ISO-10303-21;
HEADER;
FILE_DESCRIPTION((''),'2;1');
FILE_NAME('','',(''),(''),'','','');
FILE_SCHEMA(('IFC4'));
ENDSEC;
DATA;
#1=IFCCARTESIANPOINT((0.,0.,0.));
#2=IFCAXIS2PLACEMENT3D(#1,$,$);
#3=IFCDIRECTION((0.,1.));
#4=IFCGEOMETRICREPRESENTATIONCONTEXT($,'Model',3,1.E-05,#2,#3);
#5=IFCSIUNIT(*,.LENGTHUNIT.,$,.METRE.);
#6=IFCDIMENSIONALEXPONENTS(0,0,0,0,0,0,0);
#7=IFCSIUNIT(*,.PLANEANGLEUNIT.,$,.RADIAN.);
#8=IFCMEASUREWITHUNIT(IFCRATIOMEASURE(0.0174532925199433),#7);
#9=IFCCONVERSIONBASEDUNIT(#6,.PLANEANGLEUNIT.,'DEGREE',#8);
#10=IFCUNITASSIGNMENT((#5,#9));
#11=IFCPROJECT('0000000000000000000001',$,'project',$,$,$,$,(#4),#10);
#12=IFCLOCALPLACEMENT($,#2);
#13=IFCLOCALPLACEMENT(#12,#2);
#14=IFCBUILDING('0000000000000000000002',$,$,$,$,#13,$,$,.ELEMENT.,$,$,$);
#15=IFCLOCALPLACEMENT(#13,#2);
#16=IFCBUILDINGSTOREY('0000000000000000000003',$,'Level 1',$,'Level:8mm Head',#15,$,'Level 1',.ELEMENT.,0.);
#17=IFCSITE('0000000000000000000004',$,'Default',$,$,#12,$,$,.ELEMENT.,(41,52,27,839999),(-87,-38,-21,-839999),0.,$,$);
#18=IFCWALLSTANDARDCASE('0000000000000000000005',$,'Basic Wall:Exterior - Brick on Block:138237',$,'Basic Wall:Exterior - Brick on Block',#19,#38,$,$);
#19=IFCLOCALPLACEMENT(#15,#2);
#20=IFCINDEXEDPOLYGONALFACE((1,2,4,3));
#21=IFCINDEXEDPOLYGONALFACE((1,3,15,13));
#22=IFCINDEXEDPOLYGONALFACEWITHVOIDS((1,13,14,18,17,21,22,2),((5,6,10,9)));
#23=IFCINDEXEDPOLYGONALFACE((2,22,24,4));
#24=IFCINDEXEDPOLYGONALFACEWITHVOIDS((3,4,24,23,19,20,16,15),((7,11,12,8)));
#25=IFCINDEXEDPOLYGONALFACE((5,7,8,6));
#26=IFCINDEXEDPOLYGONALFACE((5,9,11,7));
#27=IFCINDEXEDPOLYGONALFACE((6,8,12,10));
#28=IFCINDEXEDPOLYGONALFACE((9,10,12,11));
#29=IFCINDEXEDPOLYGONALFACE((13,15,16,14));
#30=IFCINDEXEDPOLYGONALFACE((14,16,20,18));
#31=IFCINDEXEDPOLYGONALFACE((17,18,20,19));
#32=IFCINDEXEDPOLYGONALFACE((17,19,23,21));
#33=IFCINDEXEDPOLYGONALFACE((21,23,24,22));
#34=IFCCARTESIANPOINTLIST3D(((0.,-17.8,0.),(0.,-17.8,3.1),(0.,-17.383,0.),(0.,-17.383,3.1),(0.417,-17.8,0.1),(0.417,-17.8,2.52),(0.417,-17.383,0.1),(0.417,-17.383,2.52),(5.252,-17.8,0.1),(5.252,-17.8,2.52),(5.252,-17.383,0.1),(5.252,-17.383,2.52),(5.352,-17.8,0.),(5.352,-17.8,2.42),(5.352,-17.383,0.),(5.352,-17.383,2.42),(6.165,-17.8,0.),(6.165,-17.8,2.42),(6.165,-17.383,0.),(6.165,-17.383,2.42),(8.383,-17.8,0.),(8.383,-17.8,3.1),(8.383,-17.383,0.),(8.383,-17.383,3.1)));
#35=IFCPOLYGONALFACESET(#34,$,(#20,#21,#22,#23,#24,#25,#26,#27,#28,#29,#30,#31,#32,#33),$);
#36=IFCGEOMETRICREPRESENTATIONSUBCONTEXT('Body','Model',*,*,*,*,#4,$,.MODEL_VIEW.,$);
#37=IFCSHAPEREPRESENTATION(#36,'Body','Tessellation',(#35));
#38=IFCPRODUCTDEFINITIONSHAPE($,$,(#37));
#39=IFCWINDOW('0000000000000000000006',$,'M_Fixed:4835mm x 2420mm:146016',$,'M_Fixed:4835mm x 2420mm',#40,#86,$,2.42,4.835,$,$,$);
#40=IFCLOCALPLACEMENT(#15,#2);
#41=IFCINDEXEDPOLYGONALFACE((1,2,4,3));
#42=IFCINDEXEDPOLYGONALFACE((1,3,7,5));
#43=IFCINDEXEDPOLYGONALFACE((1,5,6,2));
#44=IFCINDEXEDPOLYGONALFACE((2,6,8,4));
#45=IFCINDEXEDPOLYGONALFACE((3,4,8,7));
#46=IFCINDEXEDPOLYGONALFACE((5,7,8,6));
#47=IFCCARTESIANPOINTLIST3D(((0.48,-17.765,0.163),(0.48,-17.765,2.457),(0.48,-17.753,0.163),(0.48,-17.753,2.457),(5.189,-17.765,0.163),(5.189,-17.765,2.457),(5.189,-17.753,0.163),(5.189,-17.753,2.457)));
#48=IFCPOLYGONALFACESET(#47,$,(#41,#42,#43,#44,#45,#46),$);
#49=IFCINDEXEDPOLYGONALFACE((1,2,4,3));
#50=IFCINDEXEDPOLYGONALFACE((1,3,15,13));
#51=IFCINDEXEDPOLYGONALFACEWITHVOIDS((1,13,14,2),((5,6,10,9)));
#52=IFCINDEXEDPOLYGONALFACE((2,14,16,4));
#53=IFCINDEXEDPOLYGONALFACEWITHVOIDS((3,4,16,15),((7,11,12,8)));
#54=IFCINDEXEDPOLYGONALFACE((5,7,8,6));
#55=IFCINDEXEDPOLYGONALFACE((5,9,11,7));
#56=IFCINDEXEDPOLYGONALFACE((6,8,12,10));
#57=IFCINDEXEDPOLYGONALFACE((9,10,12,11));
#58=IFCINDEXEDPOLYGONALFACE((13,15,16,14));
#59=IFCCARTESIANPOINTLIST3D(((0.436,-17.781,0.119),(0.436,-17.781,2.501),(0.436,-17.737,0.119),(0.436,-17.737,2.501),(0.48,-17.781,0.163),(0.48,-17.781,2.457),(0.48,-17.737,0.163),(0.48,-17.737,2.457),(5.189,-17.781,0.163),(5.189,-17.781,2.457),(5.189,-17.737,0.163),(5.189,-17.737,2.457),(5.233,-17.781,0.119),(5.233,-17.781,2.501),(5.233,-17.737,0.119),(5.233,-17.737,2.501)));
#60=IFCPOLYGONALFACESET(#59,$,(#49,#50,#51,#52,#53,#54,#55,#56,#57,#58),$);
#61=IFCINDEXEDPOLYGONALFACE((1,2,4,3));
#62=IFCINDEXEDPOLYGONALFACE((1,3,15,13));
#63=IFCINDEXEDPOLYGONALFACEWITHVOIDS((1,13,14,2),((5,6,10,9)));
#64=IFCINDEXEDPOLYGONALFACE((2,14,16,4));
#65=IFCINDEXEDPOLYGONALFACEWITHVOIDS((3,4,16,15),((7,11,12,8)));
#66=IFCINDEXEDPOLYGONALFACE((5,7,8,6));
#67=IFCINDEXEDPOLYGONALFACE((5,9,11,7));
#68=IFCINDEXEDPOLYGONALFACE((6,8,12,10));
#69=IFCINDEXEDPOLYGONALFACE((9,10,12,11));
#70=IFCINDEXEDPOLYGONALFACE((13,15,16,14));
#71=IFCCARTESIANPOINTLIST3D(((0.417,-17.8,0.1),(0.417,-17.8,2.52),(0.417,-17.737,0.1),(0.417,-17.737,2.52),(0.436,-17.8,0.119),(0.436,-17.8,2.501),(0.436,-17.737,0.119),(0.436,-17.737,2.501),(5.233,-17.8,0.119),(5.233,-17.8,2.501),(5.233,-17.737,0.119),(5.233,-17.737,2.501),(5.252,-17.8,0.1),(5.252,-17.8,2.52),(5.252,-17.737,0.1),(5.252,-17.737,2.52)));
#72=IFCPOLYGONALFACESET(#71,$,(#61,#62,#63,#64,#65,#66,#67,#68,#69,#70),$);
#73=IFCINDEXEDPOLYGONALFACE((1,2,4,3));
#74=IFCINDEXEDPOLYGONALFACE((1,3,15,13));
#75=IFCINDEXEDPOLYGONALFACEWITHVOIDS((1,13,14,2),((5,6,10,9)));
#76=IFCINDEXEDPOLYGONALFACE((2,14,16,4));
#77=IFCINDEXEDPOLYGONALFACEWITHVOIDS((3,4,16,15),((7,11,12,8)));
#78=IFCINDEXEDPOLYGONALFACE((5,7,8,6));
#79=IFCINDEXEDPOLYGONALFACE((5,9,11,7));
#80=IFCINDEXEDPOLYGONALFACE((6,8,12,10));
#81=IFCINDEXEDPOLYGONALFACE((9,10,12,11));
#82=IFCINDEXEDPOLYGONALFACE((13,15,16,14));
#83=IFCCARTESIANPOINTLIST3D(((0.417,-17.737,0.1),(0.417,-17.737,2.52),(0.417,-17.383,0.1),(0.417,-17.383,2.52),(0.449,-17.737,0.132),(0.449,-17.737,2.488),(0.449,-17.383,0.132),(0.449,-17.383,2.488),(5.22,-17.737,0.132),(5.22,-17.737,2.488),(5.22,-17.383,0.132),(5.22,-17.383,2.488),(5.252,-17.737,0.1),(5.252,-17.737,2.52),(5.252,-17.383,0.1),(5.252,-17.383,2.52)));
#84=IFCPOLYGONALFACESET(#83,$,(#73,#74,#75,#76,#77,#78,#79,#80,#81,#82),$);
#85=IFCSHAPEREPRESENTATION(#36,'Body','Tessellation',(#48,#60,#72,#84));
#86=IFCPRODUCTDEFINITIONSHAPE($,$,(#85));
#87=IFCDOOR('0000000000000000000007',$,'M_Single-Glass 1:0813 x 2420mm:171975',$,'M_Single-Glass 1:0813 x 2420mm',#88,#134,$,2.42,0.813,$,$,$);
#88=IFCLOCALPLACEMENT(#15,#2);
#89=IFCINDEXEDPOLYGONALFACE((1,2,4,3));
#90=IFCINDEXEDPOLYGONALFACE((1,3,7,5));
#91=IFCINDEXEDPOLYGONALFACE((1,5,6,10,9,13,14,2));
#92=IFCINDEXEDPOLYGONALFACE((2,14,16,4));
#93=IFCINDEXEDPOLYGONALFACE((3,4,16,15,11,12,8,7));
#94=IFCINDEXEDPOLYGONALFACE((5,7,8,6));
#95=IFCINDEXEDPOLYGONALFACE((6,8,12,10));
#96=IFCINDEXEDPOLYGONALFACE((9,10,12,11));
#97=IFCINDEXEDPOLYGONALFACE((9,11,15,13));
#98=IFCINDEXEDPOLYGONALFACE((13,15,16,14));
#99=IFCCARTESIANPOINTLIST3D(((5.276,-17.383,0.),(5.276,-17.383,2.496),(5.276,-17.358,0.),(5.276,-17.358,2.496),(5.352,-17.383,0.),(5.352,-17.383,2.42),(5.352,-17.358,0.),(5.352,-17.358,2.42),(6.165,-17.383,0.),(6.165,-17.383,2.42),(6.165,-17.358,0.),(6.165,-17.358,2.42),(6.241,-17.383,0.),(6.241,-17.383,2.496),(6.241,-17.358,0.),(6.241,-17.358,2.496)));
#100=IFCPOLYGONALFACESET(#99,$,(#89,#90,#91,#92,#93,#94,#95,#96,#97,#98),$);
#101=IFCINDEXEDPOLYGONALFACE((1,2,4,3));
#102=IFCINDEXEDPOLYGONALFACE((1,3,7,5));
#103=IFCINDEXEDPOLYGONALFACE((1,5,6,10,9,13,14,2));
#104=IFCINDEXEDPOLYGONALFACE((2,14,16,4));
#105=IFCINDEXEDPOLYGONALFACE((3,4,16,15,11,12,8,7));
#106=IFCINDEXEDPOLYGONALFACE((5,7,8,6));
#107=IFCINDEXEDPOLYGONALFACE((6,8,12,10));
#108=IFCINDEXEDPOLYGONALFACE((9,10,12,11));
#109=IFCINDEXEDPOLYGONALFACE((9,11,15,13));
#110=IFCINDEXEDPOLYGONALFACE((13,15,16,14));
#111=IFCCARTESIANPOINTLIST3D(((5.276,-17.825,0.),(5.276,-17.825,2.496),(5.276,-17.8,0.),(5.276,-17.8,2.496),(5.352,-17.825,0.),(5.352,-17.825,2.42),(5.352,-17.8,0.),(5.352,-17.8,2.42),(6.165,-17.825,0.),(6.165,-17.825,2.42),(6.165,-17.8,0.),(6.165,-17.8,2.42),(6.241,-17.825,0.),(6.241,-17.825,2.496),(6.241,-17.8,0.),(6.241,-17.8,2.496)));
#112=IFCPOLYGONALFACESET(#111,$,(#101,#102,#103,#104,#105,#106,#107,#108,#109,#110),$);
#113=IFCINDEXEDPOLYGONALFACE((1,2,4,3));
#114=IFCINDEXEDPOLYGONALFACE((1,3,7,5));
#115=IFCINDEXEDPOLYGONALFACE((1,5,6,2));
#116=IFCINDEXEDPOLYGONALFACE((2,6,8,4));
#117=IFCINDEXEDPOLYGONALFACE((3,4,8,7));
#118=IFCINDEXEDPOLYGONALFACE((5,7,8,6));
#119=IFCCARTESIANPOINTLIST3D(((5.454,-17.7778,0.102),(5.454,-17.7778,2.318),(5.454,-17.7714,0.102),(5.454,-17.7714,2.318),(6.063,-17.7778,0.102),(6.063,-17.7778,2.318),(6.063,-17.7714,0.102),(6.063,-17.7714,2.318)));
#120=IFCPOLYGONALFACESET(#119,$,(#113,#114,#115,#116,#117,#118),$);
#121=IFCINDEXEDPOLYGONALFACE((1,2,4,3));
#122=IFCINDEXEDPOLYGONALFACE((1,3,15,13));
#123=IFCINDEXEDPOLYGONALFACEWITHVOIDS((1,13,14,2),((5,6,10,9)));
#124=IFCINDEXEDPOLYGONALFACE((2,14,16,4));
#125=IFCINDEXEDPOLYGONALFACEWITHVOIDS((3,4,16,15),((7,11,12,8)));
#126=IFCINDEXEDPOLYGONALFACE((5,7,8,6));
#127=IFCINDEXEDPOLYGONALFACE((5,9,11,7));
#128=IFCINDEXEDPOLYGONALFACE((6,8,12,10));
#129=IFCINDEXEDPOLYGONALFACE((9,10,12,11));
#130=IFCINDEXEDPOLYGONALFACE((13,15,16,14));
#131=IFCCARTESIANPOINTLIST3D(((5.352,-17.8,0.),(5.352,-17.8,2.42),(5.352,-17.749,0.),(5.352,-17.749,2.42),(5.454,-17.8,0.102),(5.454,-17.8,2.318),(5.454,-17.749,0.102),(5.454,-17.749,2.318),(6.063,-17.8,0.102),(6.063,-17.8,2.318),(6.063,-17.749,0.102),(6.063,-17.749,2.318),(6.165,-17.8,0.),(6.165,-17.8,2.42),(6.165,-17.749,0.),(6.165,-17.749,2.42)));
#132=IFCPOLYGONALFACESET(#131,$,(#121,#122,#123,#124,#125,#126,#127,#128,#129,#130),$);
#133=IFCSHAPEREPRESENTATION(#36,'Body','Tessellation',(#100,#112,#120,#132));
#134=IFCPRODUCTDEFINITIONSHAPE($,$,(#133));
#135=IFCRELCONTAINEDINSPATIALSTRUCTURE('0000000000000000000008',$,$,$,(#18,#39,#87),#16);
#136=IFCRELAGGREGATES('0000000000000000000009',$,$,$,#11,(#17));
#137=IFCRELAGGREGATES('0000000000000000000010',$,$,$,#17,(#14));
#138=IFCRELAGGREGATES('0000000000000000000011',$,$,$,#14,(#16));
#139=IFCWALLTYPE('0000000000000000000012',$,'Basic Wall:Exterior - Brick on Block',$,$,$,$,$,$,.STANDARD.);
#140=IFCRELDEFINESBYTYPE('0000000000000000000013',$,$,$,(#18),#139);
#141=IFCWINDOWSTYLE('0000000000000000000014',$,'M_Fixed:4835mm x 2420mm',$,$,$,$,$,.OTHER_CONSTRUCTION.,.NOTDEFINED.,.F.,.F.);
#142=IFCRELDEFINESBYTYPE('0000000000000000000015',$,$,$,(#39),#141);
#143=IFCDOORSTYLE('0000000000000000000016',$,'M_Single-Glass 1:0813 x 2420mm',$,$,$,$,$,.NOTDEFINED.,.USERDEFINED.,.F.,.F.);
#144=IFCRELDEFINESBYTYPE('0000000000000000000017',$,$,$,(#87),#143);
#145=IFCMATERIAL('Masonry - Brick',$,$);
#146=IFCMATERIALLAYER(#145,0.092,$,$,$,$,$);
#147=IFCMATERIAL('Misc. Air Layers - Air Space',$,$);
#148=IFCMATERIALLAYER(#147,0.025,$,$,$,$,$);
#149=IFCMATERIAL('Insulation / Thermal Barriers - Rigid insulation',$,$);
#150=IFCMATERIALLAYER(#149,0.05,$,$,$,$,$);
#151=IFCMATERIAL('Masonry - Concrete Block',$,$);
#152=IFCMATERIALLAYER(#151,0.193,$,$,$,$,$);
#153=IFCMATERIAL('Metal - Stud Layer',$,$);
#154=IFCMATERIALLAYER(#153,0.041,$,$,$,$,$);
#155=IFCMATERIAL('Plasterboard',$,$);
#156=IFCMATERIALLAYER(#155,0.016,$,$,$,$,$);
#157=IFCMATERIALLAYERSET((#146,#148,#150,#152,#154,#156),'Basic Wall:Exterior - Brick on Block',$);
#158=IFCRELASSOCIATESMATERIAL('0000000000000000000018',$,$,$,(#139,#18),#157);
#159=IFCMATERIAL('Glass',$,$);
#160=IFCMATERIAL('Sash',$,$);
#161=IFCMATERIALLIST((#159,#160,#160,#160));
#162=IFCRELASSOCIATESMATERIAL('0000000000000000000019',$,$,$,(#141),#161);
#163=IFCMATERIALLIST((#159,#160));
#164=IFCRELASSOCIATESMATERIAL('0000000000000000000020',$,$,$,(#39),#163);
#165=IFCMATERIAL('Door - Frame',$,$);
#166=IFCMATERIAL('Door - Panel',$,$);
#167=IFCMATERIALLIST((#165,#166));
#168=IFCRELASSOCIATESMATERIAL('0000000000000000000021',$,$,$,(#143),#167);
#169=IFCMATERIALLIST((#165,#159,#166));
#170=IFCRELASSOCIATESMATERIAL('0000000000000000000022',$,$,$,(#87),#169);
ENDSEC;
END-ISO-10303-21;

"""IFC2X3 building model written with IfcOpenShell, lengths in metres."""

from ifc_helpers import new_model, entity, si_unit, converted_unit, direction, frame, frame_2d, origin, origin_2d_with_axis, place, context, subcontext, project, spatial, polyline, rectangle, outline, extrude, source, transform, mapped, material, material_list, layer, layer_set, layer_usage, type_object, type_shapes, element, fill, save


model = new_model("IFC2X3")

# Units and contexts
model_context = context("Model", 3, precision=1e-05, world=origin(), true_north=direction((0.0, 1.0)))
body_context = subcontext(model_context, "Body", "Model", "MODEL_VIEW")
ifc_project = project(units=[si_unit("LENGTHUNIT", "METRE"), converted_unit("PLANEANGLEUNIT", "DEGREE", entity("IfcRatioMeasure", 0.0174532925199433), si_unit("PLANEANGLEUNIT", "RADIAN"), dimensions=[0, 0, 0, 0, 0, 0, 0])], contexts=[model_context])

# Site, building, storey
site_placement = place(None, origin())
site = spatial("IfcSite", under=ifc_project, at=site_placement, Name="Default", CompositionType="ELEMENT", RefLatitude=(41, 52, 27, 839999), RefLongitude=(-87, -38, -21, -839999), RefElevation=0.0)
building_placement = place(site_placement, origin())
building = spatial("IfcBuilding", under=site, at=building_placement, CompositionType="ELEMENT")
storey_placement = place(building_placement, origin())
storey = spatial("IfcBuildingStorey", under=building, at=storey_placement, Name="Level 1", ObjectType="Level:8mm Head", LongName="Level 1", CompositionType="ELEMENT", Elevation=0.0)

# Wall, openings, window, door
ifc_material_1 = material(Name="Masonry - Brick")
ifc_layer_1 = layer(ifc_material_1, 0.092)
ifc_material_2 = material(Name="Misc. Air Layers - Air Space")
ifc_layer_2 = layer(ifc_material_2, 0.025)
ifc_material_3 = material(Name="Insulation / Thermal Barriers - Rigid insulation")
ifc_layer_3 = layer(ifc_material_3, 0.05)
ifc_material_4 = material(Name="Masonry - Concrete Block")
ifc_layer_4 = layer(ifc_material_4, 0.193)
ifc_material_5 = material(Name="Metal - Stud Layer")
ifc_layer_5 = layer(ifc_material_5, 0.041)
ifc_material_6 = material(Name="Plasterboard")
ifc_layer_6 = layer(ifc_material_6, 0.016)
ifc_layer_set_1 = layer_set([ifc_layer_1, ifc_layer_2, ifc_layer_3, ifc_layer_4, ifc_layer_5, ifc_layer_6], Name="Basic Wall:Exterior - Brick on Block")
ifc_layer_usage_1 = layer_usage(ifc_layer_set_1, "AXIS2", "NEGATIVE", 0.2085)
wall_type_1 = type_object("IfcWallType", Name="Basic Wall:Exterior - Brick on Block", PredefinedType="STANDARD", material=ifc_layer_set_1)
wall_1_placement = place(storey_placement, frame((8.383, -17.5915, 0.0), z_axis=(0.0, 0.0, 1.0), x_axis=(-1.0, 0.0, 0.0)))
wall_1 = element("IfcWallStandardCase", 1, at=wall_1_placement, inside=storey, type_object=wall_type_1, material=ifc_layer_usage_1, Name="Basic Wall:Exterior - Brick on Block:138237", ObjectType="Basic Wall:Exterior - Brick on Block", context=body_context, shape_type="SweptSolid", body=[
    extrude(rectangle(XDim=8.383, YDim=0.417, at=frame_2d((4.1915, 0.0), x_axis=(-1.0, 0.0))), origin(), (0.0, 0.0, 1.0), 3.1),
])
opening_1_placement = place(wall_1_placement, frame((2.218, -0.2085, 0.0)))
opening_1 = element("IfcOpeningElement", 2, at=opening_1_placement, cuts=wall_1, ObjectType="Opening", context=body_context, shape_type="SweptSolid", body=[
    extrude(rectangle(XDim=0.813, YDim=2.42, at=frame_2d((1.21, 0.4065), x_axis=(0.0, -1.0))), frame((0.0, 0.0, 0.0), z_axis=(0.0, 1.0, 0.0), x_axis=(0.0, 0.0, 1.0)), (0.0, 0.0, 1.0), 0.417),
])
opening_2_placement = place(wall_1_placement, frame((3.131, -0.2085, 0.1)))
opening_2 = element("IfcOpeningElement", 3, at=opening_2_placement, cuts=wall_1, ObjectType="Opening", context=body_context, shape_type="SweptSolid", body=[
    extrude(rectangle(XDim=2.42, YDim=4.835, at=frame_2d((1.21, 2.4175), x_axis=(1.0, 0.0))), frame((0.0, 0.0, 0.0), z_axis=(0.0, 1.0, 0.0), x_axis=(0.0, 0.0, 1.0)), (0.0, 0.0, 1.0), 0.417),
])
ifc_material_7 = material(Name="Glass")
ifc_material_8 = material(Name="Sash")
ifc_material_list_1 = material_list([ifc_material_7, ifc_material_8])
ifc_material_list_2 = material_list([ifc_material_7, ifc_material_8, ifc_material_8, ifc_material_8])
window_style_1 = type_object("IfcWindowStyle", Name="M_Fixed:4835mm x 2420mm", ConstructionType="OTHER_CONSTRUCTION", OperationType="NOTDEFINED", ParameterTakesPrecedence=False, Sizeable=False, material=ifc_material_list_2)
shared_shape_1 = source(origin(), body_context, "Body", "SweptSolid", [
    extrude(rectangle(XDim=0.012, YDim=4.709, at=origin_2d_with_axis()), frame((2.4175, 0.376, 0.063), z_axis=(0.0, 0.0, 1.0), x_axis=(0.0, -1.0, 0.0)), (0.0, 0.0, 1.0), 2.294),
    extrude(outline(polyline([(-2.3985, -1.191), (2.3985, -1.191), (2.3985, 1.191), (-2.3985, 1.191), (-2.3985, -1.191)]), holes=[polyline([(-2.3545, -1.147), (-2.3545, 1.147), (2.3545, 1.147), (2.3545, -1.147), (-2.3545, -1.147)])]), frame((2.4175, 0.354, 1.21), z_axis=(0.0, 1.0, 0.0), x_axis=(1.0, 0.0, 0.0)), (0.0, 0.0, 1.0), 0.044),
    extrude(outline(polyline([(-2.4175, -1.21), (2.4175, -1.21), (2.4175, 1.21), (-2.4175, 1.21), (-2.4175, -1.21)]), holes=[polyline([(-2.3985, -1.191), (-2.3985, 1.191), (2.3985, 1.191), (2.3985, -1.191), (-2.3985, -1.191)])]), frame((2.4175, 0.354, 1.21), z_axis=(0.0, 1.0, 0.0), x_axis=(1.0, 0.0, 0.0)), (0.0, 0.0, 1.0), 0.063),
    extrude(outline(polyline([(-2.4175, -1.21), (2.4175, -1.21), (2.4175, 1.21), (-2.4175, 1.21), (-2.4175, -1.21)]), holes=[polyline([(-2.3855, -1.178), (-2.3855, 1.178), (2.3855, 1.178), (2.3855, -1.178), (-2.3855, -1.178)])]), frame((2.4175, 0.0, 1.21), z_axis=(0.0, 1.0, 0.0), x_axis=(1.0, 0.0, 0.0)), (0.0, 0.0, 1.0), 0.354),
])
type_shapes(window_style_1, [shared_shape_1])
window_1_placement = place(opening_2_placement, origin())
window_1 = element("IfcWindow", 4, at=window_1_placement, inside=storey, type_object=window_style_1, material=ifc_material_list_1, Name="M_Fixed:4835mm x 2420mm:146016", ObjectType="M_Fixed:4835mm x 2420mm", OverallHeight=2.42, OverallWidth=4.835, context=body_context, shape_type="MappedRepresentation", body=[
    mapped(shared_shape_1, transform((0.0, 0.0, 0.0), scale=1.0)),
])
fill(opening_2, window_1)
ifc_material_9 = material(Name="Door - Frame")
ifc_material_10 = material(Name="Door - Panel")
ifc_material_list_3 = material_list([ifc_material_9, ifc_material_7, ifc_material_10])
ifc_material_list_4 = material_list([ifc_material_9, ifc_material_10])
door_style_1 = type_object("IfcDoorStyle", Name="M_Single-Glass 1:0813 x 2420mm", ConstructionType="USERDEFINED", OperationType="NOTDEFINED", ParameterTakesPrecedence=False, Sizeable=False, material=ifc_material_list_4)
shared_shape_2 = source(origin(), body_context, "Body", "SweptSolid", [
    extrude(outline(polyline([(-0.4065, -1.191), (-0.4065, 1.229), (-0.4825, 1.229), (-0.4825, -1.267), (0.4825, -1.267), (0.4825, 1.229), (0.4065, 1.229), (0.4065, -1.191), (-0.4065, -1.191)])), frame((0.4065, 0.0, 1.229), z_axis=(0.0, 1.0, 0.0), x_axis=(1.0, 0.0, 0.0)), (0.0, 0.0, -1.0), 0.025),
    extrude(outline(polyline([(-0.4065, -1.191), (-0.4065, 1.229), (-0.4825, 1.229), (-0.4825, -1.267), (0.4825, -1.267), (0.4825, 1.229), (0.4065, 1.229), (0.4065, -1.191), (-0.4065, -1.191)])), frame((0.4065, 0.442, 1.229), z_axis=(0.0, 1.0, 0.0), x_axis=(1.0, 0.0, 0.0)), (0.0, 0.0, -1.0), 0.025),
    extrude(rectangle(XDim=0.609, YDim=0.0064, at=frame_2d((0.0, 0.0), x_axis=(1.0, 0.0))), frame((0.4065, 0.3916, 0.102)), (0.0, 0.0, 1.0), 2.216),
    extrude(outline(polyline([(-1.21, -0.4065), (1.21, -0.4065), (1.21, 0.4065), (-1.21, 0.4065), (-1.21, -0.4065)]), holes=[polyline([(-1.108, 0.3045), (1.108, 0.3045), (1.108, -0.3045), (-1.108, -0.3045), (-1.108, 0.3045)])]), frame((0.4065, 0.417, 1.21), z_axis=(0.0, -1.0, 0.0), x_axis=(0.0, 0.0, -1.0)), (0.0, 0.0, 1.0), 0.051),
])
type_shapes(door_style_1, [shared_shape_2])
door_1_placement = place(opening_1_placement, origin())
door_1 = element("IfcDoor", 5, at=door_1_placement, inside=storey, type_object=door_style_1, material=ifc_material_list_3, Name="M_Single-Glass 1:0813 x 2420mm:171975", ObjectType="M_Single-Glass 1:0813 x 2420mm", OverallHeight=2.42, OverallWidth=0.813, context=body_context, shape_type="MappedRepresentation", body=[
    mapped(shared_shape_2, transform((0.0, 0.0, 0.0), scale=1.0)),
])
fill(opening_1, door_1)

save(model, "model.ifc")
